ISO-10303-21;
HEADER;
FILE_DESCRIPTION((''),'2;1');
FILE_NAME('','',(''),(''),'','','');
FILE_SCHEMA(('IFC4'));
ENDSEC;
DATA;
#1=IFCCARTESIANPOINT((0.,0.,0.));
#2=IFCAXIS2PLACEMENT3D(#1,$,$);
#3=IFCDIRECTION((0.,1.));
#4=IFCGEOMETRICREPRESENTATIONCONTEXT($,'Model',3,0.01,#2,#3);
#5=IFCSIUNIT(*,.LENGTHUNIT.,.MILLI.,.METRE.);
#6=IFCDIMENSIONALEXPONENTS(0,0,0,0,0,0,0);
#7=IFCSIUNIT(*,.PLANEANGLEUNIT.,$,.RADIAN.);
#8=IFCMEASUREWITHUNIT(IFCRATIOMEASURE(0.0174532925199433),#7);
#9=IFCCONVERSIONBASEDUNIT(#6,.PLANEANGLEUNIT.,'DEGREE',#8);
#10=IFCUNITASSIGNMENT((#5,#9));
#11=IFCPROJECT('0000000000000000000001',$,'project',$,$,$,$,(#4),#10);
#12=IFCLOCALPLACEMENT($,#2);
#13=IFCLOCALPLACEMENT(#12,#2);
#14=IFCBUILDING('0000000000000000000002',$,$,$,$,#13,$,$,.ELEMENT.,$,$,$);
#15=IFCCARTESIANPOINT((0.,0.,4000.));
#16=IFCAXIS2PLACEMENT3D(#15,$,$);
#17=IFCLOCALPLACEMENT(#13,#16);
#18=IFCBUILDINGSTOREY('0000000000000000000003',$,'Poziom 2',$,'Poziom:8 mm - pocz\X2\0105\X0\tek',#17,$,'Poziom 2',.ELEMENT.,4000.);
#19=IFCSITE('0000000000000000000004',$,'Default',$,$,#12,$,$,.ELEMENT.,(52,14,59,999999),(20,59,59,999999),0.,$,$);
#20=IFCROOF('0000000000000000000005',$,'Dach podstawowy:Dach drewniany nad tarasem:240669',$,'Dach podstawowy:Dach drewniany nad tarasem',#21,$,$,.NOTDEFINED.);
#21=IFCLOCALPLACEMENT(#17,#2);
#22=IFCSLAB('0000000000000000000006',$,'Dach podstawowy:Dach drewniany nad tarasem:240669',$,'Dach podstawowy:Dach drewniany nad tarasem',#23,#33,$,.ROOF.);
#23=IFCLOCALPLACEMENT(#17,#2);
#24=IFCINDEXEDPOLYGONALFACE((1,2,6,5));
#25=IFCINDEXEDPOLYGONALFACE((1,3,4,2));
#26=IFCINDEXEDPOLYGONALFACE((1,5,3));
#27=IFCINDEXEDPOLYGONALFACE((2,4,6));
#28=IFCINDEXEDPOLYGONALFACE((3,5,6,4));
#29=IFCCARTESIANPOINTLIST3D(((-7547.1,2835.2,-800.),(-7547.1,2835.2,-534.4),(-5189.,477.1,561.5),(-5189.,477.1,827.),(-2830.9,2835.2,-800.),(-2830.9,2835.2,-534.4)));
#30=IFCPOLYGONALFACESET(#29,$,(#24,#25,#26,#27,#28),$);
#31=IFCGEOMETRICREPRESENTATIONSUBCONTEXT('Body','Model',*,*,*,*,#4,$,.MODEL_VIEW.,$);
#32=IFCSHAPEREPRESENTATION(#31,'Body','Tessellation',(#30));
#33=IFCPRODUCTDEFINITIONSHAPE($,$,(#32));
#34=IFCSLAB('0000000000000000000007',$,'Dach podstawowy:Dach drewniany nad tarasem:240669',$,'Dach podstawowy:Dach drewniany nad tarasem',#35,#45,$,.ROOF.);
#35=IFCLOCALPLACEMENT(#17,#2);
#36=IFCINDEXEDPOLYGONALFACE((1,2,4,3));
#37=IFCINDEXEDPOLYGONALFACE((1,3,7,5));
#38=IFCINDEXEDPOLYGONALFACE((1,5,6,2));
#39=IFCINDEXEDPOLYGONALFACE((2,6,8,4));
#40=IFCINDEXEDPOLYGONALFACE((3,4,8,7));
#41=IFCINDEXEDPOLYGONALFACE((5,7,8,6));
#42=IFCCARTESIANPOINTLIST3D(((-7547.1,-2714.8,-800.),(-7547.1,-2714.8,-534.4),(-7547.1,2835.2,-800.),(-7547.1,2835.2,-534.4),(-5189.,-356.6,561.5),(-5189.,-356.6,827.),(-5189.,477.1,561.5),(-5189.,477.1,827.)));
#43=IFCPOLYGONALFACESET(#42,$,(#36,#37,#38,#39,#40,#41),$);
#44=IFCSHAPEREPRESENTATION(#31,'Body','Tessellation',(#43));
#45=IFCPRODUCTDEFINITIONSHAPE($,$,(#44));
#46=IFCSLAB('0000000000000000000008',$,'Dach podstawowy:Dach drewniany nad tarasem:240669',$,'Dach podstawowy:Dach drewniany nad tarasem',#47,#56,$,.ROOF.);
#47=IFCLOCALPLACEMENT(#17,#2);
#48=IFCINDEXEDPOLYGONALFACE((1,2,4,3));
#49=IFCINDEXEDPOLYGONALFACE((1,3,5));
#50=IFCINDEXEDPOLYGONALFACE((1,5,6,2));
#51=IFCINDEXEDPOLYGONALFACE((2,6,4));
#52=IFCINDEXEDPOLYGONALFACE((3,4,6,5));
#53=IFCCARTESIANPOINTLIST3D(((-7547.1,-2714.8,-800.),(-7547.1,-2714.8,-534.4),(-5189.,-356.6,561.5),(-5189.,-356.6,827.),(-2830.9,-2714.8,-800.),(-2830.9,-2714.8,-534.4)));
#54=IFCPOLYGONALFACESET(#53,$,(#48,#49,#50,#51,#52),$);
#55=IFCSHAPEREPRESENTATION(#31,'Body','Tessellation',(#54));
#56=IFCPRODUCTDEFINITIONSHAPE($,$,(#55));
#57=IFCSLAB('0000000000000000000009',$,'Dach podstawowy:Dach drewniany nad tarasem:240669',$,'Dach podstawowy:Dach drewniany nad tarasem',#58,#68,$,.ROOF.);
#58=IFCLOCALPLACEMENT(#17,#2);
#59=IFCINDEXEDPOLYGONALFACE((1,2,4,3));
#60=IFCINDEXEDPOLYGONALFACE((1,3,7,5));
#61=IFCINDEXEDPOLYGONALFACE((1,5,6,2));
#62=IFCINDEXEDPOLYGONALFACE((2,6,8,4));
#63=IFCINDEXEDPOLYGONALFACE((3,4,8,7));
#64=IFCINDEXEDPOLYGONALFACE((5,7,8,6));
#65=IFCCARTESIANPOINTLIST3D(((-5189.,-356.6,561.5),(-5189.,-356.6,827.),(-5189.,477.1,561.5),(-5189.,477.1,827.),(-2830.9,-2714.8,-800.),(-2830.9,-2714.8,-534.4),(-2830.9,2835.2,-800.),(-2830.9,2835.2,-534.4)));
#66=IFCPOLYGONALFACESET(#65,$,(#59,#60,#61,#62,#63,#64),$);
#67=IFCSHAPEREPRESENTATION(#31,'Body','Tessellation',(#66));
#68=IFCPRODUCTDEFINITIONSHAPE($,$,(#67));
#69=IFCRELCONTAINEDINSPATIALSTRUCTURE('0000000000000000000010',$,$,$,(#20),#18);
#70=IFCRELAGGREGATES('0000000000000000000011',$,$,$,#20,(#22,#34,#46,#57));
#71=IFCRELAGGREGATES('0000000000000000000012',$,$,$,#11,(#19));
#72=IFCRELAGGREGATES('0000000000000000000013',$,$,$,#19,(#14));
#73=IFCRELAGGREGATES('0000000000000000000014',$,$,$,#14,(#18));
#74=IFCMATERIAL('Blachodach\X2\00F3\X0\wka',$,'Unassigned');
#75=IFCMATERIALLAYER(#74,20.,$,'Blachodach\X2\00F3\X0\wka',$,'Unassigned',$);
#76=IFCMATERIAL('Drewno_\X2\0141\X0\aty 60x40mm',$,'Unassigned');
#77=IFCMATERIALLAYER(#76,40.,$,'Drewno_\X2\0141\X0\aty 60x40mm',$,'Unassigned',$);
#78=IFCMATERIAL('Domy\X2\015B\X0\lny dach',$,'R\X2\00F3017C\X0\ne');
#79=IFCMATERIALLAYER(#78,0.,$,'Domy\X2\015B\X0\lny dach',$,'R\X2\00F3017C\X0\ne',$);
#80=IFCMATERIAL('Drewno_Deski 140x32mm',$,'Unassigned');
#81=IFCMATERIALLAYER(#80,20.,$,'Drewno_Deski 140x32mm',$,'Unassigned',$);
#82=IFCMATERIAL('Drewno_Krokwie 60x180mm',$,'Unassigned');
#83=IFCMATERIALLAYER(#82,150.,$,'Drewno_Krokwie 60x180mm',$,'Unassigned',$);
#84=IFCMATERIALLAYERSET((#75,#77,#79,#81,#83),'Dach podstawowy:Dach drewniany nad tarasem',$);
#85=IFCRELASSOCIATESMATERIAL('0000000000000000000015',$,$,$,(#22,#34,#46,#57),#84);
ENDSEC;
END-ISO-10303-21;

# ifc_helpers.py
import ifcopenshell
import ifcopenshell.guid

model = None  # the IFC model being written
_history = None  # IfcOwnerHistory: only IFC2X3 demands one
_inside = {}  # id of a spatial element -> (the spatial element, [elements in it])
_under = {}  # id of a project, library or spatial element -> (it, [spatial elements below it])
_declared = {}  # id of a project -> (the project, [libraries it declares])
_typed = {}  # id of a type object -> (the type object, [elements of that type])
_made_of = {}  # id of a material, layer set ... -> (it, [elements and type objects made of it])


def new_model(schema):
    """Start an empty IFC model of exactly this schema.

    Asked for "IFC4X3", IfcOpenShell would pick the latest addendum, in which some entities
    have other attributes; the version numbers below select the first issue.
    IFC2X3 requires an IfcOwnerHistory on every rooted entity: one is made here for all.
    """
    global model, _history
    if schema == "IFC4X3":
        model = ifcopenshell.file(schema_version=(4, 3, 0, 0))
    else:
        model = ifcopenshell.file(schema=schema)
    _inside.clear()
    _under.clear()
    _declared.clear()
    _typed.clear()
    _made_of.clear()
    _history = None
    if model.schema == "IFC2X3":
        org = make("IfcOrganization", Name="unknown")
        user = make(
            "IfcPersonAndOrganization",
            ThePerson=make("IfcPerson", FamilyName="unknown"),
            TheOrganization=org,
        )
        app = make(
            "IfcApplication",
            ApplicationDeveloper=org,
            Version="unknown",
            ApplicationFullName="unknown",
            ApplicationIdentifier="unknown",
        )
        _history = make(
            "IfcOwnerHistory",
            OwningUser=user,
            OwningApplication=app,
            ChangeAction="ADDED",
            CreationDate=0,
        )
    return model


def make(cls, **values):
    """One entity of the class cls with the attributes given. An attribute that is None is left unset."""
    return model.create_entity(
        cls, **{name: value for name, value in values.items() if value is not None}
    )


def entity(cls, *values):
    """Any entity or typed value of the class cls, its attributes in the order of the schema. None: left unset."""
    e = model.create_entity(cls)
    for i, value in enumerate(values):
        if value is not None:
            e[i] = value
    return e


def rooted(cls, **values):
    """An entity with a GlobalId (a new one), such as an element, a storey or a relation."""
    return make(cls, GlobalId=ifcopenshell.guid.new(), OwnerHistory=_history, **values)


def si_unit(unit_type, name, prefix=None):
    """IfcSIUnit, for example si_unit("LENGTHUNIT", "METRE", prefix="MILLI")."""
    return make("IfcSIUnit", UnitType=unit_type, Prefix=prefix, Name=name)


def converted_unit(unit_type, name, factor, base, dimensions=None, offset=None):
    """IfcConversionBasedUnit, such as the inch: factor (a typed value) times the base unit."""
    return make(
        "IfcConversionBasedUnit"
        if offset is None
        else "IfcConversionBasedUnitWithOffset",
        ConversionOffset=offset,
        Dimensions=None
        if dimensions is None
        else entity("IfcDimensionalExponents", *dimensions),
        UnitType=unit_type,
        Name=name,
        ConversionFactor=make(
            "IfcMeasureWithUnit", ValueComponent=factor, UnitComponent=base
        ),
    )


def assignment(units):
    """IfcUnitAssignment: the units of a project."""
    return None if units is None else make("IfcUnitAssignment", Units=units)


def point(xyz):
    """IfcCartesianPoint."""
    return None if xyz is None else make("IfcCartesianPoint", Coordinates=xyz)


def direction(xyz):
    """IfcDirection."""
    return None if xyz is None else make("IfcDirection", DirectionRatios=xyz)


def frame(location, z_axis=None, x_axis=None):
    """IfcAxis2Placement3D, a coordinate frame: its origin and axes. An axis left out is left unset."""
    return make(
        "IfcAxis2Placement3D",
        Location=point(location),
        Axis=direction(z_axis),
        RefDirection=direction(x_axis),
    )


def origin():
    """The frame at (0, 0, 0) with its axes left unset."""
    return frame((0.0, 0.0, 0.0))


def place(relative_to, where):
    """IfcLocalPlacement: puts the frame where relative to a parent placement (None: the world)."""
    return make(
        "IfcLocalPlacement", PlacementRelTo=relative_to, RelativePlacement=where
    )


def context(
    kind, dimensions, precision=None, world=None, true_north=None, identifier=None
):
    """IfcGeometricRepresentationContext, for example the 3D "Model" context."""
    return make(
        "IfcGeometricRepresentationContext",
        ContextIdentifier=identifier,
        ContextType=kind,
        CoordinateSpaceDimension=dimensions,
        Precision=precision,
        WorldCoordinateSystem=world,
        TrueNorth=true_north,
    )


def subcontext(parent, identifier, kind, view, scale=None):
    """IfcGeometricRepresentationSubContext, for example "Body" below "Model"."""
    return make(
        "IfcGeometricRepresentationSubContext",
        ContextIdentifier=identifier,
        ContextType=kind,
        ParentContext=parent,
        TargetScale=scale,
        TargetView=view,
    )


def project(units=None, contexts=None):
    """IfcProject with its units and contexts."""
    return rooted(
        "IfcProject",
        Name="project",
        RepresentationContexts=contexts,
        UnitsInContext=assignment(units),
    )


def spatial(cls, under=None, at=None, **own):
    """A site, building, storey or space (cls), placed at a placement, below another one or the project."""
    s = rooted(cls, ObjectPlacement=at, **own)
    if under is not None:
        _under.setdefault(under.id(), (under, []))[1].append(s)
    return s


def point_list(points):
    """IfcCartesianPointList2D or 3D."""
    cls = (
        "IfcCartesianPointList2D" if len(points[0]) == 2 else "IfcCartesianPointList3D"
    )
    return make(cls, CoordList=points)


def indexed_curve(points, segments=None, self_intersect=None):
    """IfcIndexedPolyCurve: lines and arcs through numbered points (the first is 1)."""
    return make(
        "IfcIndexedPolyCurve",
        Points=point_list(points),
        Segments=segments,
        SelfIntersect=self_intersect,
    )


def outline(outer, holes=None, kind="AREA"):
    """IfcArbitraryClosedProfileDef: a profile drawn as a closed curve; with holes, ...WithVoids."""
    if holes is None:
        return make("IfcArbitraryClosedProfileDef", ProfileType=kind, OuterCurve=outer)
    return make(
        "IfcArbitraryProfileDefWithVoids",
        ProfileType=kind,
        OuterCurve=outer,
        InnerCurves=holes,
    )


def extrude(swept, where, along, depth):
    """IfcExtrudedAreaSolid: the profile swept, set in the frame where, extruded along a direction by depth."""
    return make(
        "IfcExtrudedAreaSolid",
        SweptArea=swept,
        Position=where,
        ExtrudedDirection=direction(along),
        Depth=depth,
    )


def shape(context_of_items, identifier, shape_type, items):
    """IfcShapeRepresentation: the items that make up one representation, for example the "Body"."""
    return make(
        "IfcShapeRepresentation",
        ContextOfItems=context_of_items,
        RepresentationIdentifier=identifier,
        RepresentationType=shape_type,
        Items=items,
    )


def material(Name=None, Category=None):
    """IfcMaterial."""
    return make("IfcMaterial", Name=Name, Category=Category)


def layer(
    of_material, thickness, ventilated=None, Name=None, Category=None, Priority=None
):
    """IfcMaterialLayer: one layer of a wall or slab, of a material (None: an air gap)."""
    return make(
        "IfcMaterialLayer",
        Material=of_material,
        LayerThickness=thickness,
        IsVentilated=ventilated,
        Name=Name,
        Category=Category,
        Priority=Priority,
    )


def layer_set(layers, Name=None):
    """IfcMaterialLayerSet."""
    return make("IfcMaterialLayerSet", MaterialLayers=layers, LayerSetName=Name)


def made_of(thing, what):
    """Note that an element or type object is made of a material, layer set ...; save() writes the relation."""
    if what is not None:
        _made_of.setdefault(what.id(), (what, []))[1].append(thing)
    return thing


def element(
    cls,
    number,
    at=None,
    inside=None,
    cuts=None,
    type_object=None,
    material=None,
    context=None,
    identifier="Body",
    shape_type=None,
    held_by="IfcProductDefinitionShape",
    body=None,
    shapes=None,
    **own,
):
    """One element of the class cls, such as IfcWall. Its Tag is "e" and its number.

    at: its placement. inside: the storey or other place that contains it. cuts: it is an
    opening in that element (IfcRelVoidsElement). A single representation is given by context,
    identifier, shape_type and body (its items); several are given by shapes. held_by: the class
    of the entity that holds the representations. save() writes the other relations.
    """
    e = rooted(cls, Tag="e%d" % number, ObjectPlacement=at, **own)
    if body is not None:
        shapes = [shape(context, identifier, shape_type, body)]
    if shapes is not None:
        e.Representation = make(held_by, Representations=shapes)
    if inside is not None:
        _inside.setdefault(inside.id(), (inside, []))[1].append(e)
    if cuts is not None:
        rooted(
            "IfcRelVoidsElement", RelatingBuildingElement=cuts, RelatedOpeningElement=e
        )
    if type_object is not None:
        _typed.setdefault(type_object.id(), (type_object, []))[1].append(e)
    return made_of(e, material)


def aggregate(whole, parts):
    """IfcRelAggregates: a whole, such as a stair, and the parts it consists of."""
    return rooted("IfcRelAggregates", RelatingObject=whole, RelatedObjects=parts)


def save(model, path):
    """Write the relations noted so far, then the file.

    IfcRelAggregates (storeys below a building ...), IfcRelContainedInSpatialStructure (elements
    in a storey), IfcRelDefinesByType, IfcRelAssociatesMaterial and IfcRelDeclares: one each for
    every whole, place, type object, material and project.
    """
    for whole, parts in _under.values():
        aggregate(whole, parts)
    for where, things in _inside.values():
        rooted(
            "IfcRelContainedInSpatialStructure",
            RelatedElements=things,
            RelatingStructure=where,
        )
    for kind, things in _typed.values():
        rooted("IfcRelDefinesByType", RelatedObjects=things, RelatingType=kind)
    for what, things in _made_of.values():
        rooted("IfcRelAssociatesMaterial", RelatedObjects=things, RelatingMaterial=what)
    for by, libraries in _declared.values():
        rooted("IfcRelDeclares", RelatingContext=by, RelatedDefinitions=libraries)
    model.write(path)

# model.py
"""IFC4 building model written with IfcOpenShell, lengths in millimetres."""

from ifc_helpers import new_model, entity, si_unit, converted_unit, direction, frame, origin, place, context, subcontext, project, spatial, indexed_curve, outline, extrude, material, layer, layer_set, element, aggregate, save


model = new_model("IFC4")

# Units and contexts
model_context = context("Model", 3, precision=0.01, world=origin(), true_north=direction((0.0, 1.0)))
body_context = subcontext(model_context, "Body", "Model", "MODEL_VIEW")
ifc_project = project(units=[si_unit("LENGTHUNIT", "METRE", prefix="MILLI"), converted_unit("PLANEANGLEUNIT", "DEGREE", entity("IfcRatioMeasure", 0.0174532925199433), si_unit("PLANEANGLEUNIT", "RADIAN"), dimensions=[0, 0, 0, 0, 0, 0, 0])], contexts=[model_context])

# Site, building, storey
site_placement = place(None, origin())
site = spatial("IfcSite", under=ifc_project, at=site_placement, Name="Default", CompositionType="ELEMENT", RefLatitude=(52, 14, 59, 999999), RefLongitude=(20, 59, 59, 999999), RefElevation=0.0)
building_placement = place(site_placement, origin())
building = spatial("IfcBuilding", under=site, at=building_placement, CompositionType="ELEMENT")
storey_placement = place(building_placement, frame((0.0, 0.0, 4000.0)))
storey = spatial("IfcBuildingStorey", under=building, at=storey_placement, Name="Poziom 2", ObjectType="Poziom:8 mm - początek", LongName="Poziom 2", CompositionType="ELEMENT", Elevation=4000.0)

# Roof, slabs
roof_placement = place(storey_placement, frame((-7547.1, -2714.8, -800.0)))
roof = element("IfcRoof", 1, at=roof_placement, inside=storey, Name="Dach podstawowy:Dach drewniany nad tarasem:240669", ObjectType="Dach podstawowy:Dach drewniany nad tarasem", PredefinedType="NOTDEFINED")
ifc_material_1 = material(Name="Blachodachówka", Category="Unassigned")
ifc_layer_1 = layer(ifc_material_1, 20.0, Name="Blachodachówka", Category="Unassigned")
ifc_material_2 = material(Name="Drewno_Łaty 60x40mm", Category="Unassigned")
ifc_layer_2 = layer(ifc_material_2, 40.0, Name="Drewno_Łaty 60x40mm", Category="Unassigned")
ifc_material_3 = material(Name="Domyślny dach", Category="Różne")
ifc_layer_3 = layer(ifc_material_3, 0.0, Name="Domyślny dach", Category="Różne")
ifc_material_4 = material(Name="Drewno_Deski 140x32mm", Category="Unassigned")
ifc_layer_4 = layer(ifc_material_4, 20.0, Name="Drewno_Deski 140x32mm", Category="Unassigned")
ifc_material_5 = material(Name="Drewno_Krokwie 60x180mm", Category="Unassigned")
ifc_layer_5 = layer(ifc_material_5, 150.0, Name="Drewno_Krokwie 60x180mm", Category="Unassigned")
ifc_layer_set = layer_set([ifc_layer_1, ifc_layer_2, ifc_layer_3, ifc_layer_4, ifc_layer_5], Name="Dach podstawowy:Dach drewniany nad tarasem")
slab_1_placement = place(roof_placement, origin())
slab_1 = element("IfcSlab", 2, at=slab_1_placement, material=ifc_layer_set, Name="Dach podstawowy:Dach drewniany nad tarasem:240669", ObjectType="Dach podstawowy:Dach drewniany nad tarasem", PredefinedType="ROOF", context=body_context, shape_type="SweptSolid", body=[
    extrude(outline(indexed_curve([(2358.1, 1361.5), (-2358.1, 1361.5), (0.0, -1361.5), (2358.1, 1361.5)], self_intersect=False)), frame((2358.1, 4370.9, 680.7), z_axis=(0.0, 0.5, 0.866025), x_axis=(1.0, 0.0, 0.0)), (0.0, -0.5, 0.866025), 265.6),
])
slab_2_placement = place(roof_placement, origin())
slab_2 = element("IfcSlab", 3, at=slab_2_placement, material=ifc_layer_set, Name="Dach podstawowy:Dach drewniany nad tarasem:240669", ObjectType="Dach podstawowy:Dach drewniany nad tarasem", PredefinedType="ROOF", context=body_context, shape_type="SweptSolid", body=[
    extrude(outline(indexed_curve([(-1361.5, 2775.0), (-1361.5, -2775.0), (1361.5, -416.9), (1361.5, 416.9), (-1361.5, 2775.0)], self_intersect=False)), frame((1179.1, 2775.0, 680.7), z_axis=(-0.5, 0.0, 0.866025), x_axis=(0.866025, 0.0, 0.5)), (0.5, 0.0, 0.866025), 265.6),
])
slab_3_placement = place(roof_placement, origin())
slab_3 = element("IfcSlab", 4, at=slab_3_placement, material=ifc_layer_set, Name="Dach podstawowy:Dach drewniany nad tarasem:240669", ObjectType="Dach podstawowy:Dach drewniany nad tarasem", PredefinedType="ROOF", context=body_context, shape_type="SweptSolid", body=[
    extrude(outline(indexed_curve([(-2358.1, -1361.5), (2358.1, -1361.5), (0.0, 1361.5), (-2358.1, -1361.5)], self_intersect=False)), frame((2358.1, 1179.1, 680.7), z_axis=(0.0, -0.5, 0.866025), x_axis=(1.0, 0.0, 0.0)), (0.0, 0.5, 0.866025), 265.6),
])
slab_4_placement = place(roof_placement, origin())
slab_4 = element("IfcSlab", 5, at=slab_4_placement, material=ifc_layer_set, Name="Dach podstawowy:Dach drewniany nad tarasem:240669", ObjectType="Dach podstawowy:Dach drewniany nad tarasem", PredefinedType="ROOF", context=body_context, shape_type="SweptSolid", body=[
    extrude(outline(indexed_curve([(-1361.5, 416.9), (-1361.5, -416.9), (1361.5, -2775.0), (1361.5, 2775.0), (-1361.5, 416.9)], self_intersect=False)), frame((3537.2, 2775.0, 680.7), z_axis=(0.5, 0.0, 0.866025), x_axis=(0.866025, 0.0, -0.5)), (-0.5, 0.0, 0.866025), 265.6),
])
aggregate(roof, [slab_1, slab_2, slab_3, slab_4])

save(model, "model.ifc")
